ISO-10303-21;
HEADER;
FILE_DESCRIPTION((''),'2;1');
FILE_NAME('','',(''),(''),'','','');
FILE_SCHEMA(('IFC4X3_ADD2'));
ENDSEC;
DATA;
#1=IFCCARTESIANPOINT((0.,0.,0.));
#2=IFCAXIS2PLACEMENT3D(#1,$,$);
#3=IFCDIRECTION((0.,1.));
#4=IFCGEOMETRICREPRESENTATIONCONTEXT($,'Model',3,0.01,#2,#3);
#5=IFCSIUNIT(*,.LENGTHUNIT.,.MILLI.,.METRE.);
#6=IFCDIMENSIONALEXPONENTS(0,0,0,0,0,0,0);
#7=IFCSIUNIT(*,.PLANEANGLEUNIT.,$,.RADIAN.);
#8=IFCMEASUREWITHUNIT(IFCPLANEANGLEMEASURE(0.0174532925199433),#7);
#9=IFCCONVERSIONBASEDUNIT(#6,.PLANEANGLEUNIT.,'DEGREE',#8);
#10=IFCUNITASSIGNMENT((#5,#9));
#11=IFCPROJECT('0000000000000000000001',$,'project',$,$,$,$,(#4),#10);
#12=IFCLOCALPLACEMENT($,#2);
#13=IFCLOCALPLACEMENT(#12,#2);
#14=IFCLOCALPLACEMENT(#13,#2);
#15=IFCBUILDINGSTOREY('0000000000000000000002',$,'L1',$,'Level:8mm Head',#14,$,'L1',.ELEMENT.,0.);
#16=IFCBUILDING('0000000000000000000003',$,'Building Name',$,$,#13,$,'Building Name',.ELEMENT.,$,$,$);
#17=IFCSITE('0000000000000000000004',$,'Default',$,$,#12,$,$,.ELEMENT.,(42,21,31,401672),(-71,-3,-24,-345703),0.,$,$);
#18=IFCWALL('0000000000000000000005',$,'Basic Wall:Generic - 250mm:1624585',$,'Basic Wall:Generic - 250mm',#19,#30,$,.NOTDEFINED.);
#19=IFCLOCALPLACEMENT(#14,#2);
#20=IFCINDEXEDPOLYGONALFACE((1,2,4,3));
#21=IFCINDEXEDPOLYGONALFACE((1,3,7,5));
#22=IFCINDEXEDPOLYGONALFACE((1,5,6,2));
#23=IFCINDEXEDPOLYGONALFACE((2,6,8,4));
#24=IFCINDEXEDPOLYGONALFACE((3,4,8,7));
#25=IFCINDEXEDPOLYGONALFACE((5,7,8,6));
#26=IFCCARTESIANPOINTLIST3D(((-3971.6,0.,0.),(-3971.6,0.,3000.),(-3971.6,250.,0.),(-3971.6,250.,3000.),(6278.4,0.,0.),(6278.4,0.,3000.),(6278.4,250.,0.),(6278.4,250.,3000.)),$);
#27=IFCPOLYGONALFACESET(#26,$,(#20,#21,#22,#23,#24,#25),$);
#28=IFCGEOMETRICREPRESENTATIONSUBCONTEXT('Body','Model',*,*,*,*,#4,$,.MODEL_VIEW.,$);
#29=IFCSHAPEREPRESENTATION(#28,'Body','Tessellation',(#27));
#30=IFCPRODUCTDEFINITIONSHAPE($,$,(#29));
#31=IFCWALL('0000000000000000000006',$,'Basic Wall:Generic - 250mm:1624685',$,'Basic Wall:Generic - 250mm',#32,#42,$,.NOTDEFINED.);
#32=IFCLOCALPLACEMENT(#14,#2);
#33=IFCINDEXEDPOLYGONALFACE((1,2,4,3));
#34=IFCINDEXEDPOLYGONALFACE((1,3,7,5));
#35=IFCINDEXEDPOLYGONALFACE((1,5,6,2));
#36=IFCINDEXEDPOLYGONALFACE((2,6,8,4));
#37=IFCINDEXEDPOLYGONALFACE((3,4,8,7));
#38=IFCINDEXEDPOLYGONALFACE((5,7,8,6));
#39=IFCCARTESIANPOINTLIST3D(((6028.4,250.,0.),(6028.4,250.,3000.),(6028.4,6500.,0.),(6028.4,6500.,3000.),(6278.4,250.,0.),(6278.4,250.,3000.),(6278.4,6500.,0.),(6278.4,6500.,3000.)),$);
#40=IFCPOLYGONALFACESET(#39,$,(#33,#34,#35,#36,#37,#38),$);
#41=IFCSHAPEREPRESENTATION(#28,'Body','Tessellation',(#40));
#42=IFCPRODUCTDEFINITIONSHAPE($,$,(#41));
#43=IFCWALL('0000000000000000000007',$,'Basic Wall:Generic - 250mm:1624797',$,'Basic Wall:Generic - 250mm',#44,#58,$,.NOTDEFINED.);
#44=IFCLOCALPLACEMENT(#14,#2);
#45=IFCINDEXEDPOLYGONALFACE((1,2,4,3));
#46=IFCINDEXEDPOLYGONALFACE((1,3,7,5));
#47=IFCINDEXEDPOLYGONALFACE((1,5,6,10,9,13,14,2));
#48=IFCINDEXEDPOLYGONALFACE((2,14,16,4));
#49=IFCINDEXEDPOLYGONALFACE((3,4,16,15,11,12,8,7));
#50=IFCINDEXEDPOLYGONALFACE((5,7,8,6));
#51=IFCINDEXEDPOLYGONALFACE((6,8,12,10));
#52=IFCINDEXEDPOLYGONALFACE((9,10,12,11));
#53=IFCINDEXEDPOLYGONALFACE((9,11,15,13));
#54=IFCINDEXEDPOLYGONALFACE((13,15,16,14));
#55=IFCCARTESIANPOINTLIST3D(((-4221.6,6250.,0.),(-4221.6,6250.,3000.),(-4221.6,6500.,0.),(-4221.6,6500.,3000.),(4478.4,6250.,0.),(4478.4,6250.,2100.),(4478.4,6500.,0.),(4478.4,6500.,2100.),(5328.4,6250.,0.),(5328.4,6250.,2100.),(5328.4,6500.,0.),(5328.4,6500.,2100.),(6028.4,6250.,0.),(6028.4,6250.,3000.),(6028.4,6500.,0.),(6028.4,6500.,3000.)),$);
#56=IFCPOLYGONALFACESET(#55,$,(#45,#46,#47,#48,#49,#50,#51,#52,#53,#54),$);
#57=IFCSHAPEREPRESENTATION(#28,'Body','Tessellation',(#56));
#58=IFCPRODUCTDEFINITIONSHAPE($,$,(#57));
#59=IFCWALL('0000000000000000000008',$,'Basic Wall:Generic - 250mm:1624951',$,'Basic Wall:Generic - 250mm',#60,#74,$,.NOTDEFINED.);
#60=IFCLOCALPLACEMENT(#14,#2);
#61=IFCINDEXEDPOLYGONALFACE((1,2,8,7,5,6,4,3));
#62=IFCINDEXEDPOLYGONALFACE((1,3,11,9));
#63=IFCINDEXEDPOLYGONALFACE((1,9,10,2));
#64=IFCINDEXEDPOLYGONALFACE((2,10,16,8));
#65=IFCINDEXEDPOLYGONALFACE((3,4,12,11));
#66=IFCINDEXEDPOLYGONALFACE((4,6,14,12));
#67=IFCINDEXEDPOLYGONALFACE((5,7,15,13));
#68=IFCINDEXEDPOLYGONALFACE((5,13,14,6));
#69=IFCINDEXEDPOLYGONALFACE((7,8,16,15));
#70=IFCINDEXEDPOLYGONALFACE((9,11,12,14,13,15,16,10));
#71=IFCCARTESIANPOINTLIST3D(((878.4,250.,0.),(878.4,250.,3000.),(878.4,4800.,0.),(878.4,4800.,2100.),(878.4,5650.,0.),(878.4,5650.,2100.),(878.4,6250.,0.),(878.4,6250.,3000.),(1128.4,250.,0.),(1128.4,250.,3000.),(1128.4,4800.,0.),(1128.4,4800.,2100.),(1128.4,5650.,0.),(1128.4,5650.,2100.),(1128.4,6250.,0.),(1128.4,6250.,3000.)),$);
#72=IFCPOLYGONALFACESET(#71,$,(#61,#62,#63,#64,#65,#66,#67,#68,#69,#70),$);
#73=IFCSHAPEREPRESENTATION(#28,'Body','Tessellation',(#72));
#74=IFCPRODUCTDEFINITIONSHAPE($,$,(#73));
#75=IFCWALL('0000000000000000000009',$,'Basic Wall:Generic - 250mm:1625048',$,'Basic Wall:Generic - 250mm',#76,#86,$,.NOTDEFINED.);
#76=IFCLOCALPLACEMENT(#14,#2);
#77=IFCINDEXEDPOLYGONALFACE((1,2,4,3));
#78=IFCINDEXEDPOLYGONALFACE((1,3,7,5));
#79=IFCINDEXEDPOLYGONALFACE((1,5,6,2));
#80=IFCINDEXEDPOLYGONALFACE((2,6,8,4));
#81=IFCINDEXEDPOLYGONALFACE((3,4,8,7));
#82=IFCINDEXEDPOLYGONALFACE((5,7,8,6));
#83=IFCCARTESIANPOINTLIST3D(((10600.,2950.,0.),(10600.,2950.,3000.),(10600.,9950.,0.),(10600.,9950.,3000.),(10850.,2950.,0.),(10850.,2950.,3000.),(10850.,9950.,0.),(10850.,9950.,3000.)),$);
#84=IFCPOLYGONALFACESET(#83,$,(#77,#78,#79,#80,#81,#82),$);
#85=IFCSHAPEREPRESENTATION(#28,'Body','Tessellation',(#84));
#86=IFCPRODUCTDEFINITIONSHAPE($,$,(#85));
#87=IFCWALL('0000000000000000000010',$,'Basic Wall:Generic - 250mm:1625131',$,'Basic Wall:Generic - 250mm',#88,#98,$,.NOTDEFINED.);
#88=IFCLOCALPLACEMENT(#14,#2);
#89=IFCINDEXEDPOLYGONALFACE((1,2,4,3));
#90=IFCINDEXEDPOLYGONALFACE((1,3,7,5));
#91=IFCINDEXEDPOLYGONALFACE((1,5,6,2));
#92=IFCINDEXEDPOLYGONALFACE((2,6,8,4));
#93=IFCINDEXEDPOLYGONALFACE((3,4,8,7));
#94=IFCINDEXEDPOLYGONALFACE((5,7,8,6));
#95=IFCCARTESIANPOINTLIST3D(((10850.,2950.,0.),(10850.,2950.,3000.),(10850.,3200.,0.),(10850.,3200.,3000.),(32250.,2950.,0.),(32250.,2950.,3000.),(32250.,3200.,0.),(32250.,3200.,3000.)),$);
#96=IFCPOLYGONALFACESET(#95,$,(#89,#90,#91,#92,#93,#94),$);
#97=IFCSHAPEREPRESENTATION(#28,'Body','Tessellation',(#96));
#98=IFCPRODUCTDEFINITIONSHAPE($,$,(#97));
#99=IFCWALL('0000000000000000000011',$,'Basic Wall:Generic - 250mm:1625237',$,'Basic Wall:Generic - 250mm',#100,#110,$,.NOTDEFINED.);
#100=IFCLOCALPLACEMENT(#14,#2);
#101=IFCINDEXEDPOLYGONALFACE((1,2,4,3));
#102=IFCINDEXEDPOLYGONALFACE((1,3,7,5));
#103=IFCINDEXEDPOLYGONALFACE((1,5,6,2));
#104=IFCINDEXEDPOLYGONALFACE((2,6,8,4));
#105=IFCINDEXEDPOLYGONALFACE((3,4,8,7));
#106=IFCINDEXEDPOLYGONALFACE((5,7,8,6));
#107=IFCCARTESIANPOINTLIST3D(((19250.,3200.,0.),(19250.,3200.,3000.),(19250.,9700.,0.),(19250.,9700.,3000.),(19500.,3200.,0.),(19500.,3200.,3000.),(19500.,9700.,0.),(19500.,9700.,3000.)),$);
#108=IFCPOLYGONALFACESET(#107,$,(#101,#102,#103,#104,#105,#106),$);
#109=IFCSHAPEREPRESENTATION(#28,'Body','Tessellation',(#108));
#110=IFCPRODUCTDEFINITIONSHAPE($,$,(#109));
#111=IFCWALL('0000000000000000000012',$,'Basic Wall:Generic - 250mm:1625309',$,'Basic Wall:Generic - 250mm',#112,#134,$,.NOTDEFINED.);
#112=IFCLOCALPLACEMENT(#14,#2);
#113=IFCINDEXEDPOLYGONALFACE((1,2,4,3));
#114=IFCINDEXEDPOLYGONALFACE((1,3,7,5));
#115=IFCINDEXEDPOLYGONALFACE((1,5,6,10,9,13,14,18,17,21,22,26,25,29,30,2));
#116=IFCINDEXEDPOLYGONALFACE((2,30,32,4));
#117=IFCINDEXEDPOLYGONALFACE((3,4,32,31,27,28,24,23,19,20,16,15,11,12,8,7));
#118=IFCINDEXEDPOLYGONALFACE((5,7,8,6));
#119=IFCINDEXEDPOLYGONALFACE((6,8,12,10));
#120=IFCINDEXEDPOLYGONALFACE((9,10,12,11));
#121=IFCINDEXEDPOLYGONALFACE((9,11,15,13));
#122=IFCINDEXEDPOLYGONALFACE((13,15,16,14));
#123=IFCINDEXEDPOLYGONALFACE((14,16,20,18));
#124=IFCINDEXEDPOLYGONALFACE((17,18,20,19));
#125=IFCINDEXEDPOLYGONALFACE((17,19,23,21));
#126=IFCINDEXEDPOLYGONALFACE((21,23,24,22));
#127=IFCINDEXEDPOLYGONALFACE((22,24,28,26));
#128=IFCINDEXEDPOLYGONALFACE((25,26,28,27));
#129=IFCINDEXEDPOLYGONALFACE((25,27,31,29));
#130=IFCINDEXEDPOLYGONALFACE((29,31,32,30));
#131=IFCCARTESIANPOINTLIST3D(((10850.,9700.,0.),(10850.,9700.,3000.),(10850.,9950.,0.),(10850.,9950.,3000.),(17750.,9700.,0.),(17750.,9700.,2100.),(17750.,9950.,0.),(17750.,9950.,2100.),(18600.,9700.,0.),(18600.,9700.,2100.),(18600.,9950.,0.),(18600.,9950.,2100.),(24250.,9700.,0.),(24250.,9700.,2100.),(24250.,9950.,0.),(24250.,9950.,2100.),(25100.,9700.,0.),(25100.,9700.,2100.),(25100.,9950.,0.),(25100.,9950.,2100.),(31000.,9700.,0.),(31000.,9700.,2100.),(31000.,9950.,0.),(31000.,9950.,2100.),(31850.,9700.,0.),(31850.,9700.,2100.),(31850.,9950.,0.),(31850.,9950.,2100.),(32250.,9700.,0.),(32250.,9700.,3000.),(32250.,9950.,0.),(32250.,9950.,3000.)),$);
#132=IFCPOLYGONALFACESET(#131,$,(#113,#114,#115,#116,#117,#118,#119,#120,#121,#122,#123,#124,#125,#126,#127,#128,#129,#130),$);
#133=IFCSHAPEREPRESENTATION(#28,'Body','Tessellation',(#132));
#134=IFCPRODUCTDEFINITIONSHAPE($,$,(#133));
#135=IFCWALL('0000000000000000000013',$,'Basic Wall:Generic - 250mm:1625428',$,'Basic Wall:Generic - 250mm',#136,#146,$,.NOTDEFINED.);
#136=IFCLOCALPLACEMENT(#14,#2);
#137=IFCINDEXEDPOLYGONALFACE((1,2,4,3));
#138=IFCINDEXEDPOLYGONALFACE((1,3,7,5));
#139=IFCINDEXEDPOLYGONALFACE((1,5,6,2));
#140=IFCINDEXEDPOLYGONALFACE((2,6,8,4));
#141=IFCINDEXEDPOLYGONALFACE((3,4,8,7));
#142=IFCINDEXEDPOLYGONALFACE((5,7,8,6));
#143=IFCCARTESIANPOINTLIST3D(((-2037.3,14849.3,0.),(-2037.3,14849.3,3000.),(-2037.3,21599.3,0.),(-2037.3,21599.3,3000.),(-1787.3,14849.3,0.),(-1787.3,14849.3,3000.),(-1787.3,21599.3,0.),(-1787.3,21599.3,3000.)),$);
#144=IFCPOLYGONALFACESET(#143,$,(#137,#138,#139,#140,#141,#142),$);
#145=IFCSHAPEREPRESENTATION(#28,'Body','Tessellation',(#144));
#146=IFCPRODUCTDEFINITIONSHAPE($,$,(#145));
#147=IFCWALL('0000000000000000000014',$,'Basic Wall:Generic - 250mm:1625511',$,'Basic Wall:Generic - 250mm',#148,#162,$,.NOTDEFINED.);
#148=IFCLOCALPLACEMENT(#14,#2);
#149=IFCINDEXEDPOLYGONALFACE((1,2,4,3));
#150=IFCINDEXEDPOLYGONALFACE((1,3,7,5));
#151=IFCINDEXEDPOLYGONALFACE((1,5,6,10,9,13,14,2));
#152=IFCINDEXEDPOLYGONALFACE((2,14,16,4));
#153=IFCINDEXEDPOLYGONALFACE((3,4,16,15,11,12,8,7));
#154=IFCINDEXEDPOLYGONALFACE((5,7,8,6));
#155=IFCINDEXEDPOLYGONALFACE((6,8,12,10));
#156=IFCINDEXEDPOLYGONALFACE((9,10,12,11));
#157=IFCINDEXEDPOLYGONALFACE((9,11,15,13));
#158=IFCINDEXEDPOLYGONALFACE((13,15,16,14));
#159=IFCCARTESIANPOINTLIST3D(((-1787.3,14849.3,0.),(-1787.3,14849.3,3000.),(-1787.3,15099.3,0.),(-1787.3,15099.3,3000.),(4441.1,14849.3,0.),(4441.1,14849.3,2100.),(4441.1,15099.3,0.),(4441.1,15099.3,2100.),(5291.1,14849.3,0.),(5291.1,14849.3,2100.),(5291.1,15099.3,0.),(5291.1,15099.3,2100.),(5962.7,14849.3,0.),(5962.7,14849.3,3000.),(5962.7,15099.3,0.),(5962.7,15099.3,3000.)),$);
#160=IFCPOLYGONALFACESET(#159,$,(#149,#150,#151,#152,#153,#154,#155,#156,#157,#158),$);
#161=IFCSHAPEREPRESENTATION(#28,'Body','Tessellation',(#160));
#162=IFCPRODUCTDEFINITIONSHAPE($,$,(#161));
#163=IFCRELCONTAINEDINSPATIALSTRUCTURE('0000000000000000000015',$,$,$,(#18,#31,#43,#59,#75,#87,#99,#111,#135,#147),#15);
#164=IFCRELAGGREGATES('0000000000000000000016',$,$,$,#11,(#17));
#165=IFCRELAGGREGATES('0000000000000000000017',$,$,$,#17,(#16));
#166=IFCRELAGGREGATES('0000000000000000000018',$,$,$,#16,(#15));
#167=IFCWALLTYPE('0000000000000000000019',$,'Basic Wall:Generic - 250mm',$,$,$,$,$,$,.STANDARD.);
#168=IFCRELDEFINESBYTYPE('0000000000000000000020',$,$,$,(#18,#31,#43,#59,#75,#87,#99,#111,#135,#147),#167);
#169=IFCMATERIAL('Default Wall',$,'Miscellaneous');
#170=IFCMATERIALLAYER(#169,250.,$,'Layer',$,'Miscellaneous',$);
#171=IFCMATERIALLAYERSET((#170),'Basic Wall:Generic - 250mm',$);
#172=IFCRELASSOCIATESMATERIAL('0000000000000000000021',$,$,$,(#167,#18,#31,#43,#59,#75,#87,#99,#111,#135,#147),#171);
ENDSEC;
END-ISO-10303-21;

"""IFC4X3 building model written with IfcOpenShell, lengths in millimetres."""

from ifc_helpers import new_model, entity, si_unit, converted_unit, direction, frame, frame_2d, origin, place, context, subcontext, project, spatial, rectangle, extrude, material, layer, layer_set, type_object, element, save


model = new_model("IFC4X3")

# Units and contexts
model_context = context("Model", 3, precision=0.01, world=origin(), true_north=direction((0.0, 1.0)))
body_context = subcontext(model_context, "Body", "Model", "MODEL_VIEW")
ifc_project = project(units=[si_unit("LENGTHUNIT", "METRE", prefix="MILLI"), converted_unit("PLANEANGLEUNIT", "DEGREE", entity("IfcPlaneAngleMeasure", 0.0174532925199433), si_unit("PLANEANGLEUNIT", "RADIAN"), dimensions=[0, 0, 0, 0, 0, 0, 0])], contexts=[model_context])

# Site, building, storey
site_placement = place(None, origin())
site = spatial("IfcSite", under=ifc_project, at=site_placement, Name="Default", CompositionType="ELEMENT", RefLatitude=(42, 21, 31, 401672), RefLongitude=(-71, -3, -24, -345703), RefElevation=0.0)
building_placement = place(site_placement, origin())
building = spatial("IfcBuilding", under=site, at=building_placement, Name="Building Name", LongName="Building Name", CompositionType="ELEMENT")
storey_placement = place(building_placement, origin())
storey = spatial("IfcBuildingStorey", under=building, at=storey_placement, Name="L1", ObjectType="Level:8mm Head", LongName="L1", CompositionType="ELEMENT", Elevation=0.0)

# Walls
ifc_material = material(Name="Default Wall", Category="Miscellaneous")
ifc_layer = layer(ifc_material, 250.0, Name="Layer", Category="Miscellaneous")
ifc_layer_set = layer_set([ifc_layer], Name="Basic Wall:Generic - 250mm")
wall_type = type_object("IfcWallType", Name="Basic Wall:Generic - 250mm", PredefinedType="STANDARD", material=ifc_layer_set)
wall_1_placement = place(storey_placement, frame((-3971.6, 125.0, 0.0)))
element("IfcWall", 1, at=wall_1_placement, inside=storey, type_object=wall_type, material=ifc_layer_set, Name="Basic Wall:Generic - 250mm:1624585", ObjectType="Basic Wall:Generic - 250mm", PredefinedType="NOTDEFINED", context=body_context, shape_type="SweptSolid", body=[
    extrude(rectangle(XDim=10250.0, YDim=250.0, at=frame_2d((5125.0, 0.0), x_axis=(-1.0, 0.0))), origin(), (0.0, 0.0, 1.0), 3000.0),
])
wall_2_placement = place(storey_placement, frame((6153.4, 250.0, 0.0), z_axis=(0.0, 0.0, 1.0), x_axis=(0.0, 1.0, 0.0)))
element("IfcWall", 2, at=wall_2_placement, inside=storey, type_object=wall_type, material=ifc_layer_set, Name="Basic Wall:Generic - 250mm:1624685", ObjectType="Basic Wall:Generic - 250mm", PredefinedType="NOTDEFINED", context=body_context, shape_type="SweptSolid", body=[
    extrude(rectangle(XDim=6250.0, YDim=250.0, at=frame_2d((3125.0, 0.0), x_axis=(-1.0, 0.0))), origin(), (0.0, 0.0, 1.0), 3000.0),
])

# Walls, openings
wall_3_placement = place(storey_placement, frame((6028.4, 6375.0, 0.0), z_axis=(0.0, 0.0, 1.0), x_axis=(-1.0, 0.0, 0.0)))
wall_3 = element("IfcWall", 3, at=wall_3_placement, inside=storey, type_object=wall_type, material=ifc_layer_set, Name="Basic Wall:Generic - 250mm:1624797", ObjectType="Basic Wall:Generic - 250mm", PredefinedType="NOTDEFINED", context=body_context, shape_type="SweptSolid", body=[
    extrude(rectangle(XDim=10250.0, YDim=250.0, at=frame_2d((5125.0, 0.0), x_axis=(1.0, 0.0))), origin(), (0.0, 0.0, 1.0), 3000.0),
])
opening_1_placement = place(wall_3_placement, frame((700.0, -125.0, 0.0)))
element("IfcOpeningElement", 4, at=opening_1_placement, cuts=wall_3, PredefinedType="OPENING", context=body_context, shape_type="SweptSolid", body=[
    extrude(rectangle(XDim=2100.0, YDim=850.0, at=frame_2d((1050.0, 425.0), x_axis=(1.0, 0.0))), frame((0.0, 0.0, 0.0), z_axis=(0.0, 1.0, 0.0), x_axis=(0.0, 0.0, 1.0)), (0.0, 0.0, 1.0), 250.0),
])
wall_4_placement = place(storey_placement, frame((1003.4, 6250.0, 0.0), z_axis=(0.0, 0.0, 1.0), x_axis=(0.0, -1.0, 0.0)))
wall_4 = element("IfcWall", 5, at=wall_4_placement, inside=storey, type_object=wall_type, material=ifc_layer_set, Name="Basic Wall:Generic - 250mm:1624951", ObjectType="Basic Wall:Generic - 250mm", PredefinedType="NOTDEFINED", context=body_context, shape_type="SweptSolid", body=[
    extrude(rectangle(XDim=6000.0, YDim=250.0, at=frame_2d((3000.0, 0.0), x_axis=(1.0, 0.0))), origin(), (0.0, 0.0, 1.0), 3000.0),
])
opening_2_placement = place(wall_4_placement, frame((1450.0, 125.0, 0.0)))
element("IfcOpeningElement", 6, at=opening_2_placement, cuts=wall_4, PredefinedType="OPENING", context=body_context, shape_type="SweptSolid", body=[
    extrude(rectangle(XDim=2100.0, YDim=850.0, at=frame_2d((1050.0, 425.0), x_axis=(1.0, 0.0))), frame((0.0, 0.0, 0.0), z_axis=(0.0, -1.0, 0.0), x_axis=(0.0, 0.0, 1.0)), (0.0, 0.0, 1.0), 250.0),
])

# Walls
wall_5_placement = place(storey_placement, frame((10725.0, 9950.0, 0.0), z_axis=(0.0, 0.0, 1.0), x_axis=(0.0, -1.0, 0.0)))
element("IfcWall", 7, at=wall_5_placement, inside=storey, type_object=wall_type, material=ifc_layer_set, Name="Basic Wall:Generic - 250mm:1625048", ObjectType="Basic Wall:Generic - 250mm", PredefinedType="NOTDEFINED", context=body_context, shape_type="SweptSolid", body=[
    extrude(rectangle(XDim=7000.0, YDim=250.0, at=frame_2d((3500.0, 0.0), x_axis=(-1.0, 0.0))), origin(), (0.0, 0.0, 1.0), 3000.0),
])
wall_6_placement = place(storey_placement, frame((10850.0, 3075.0, 0.0)))
element("IfcWall", 8, at=wall_6_placement, inside=storey, type_object=wall_type, material=ifc_layer_set, Name="Basic Wall:Generic - 250mm:1625131", ObjectType="Basic Wall:Generic - 250mm", PredefinedType="NOTDEFINED", context=body_context, shape_type="SweptSolid", body=[
    extrude(rectangle(XDim=21400.0, YDim=250.0, at=frame_2d((10700.0, 0.0), x_axis=(-1.0, 0.0))), origin(), (0.0, 0.0, 1.0), 3000.0),
])
wall_7_placement = place(storey_placement, frame((19375.0, 3200.0, 0.0), z_axis=(0.0, 0.0, 1.0), x_axis=(0.0, 1.0, 0.0)))
element("IfcWall", 9, at=wall_7_placement, inside=storey, type_object=wall_type, material=ifc_layer_set, Name="Basic Wall:Generic - 250mm:1625237", ObjectType="Basic Wall:Generic - 250mm", PredefinedType="NOTDEFINED", context=body_context, shape_type="SweptSolid", body=[
    extrude(rectangle(XDim=6500.0, YDim=250.0, at=frame_2d((3250.0, 0.0), x_axis=(-1.0, 0.0))), origin(), (0.0, 0.0, 1.0), 3000.0),
])

# Wall, openings
wall_8_placement = place(storey_placement, frame((32250.0, 9825.0, 0.0), z_axis=(0.0, 0.0, 1.0), x_axis=(-1.0, 0.0, 0.0)))
wall_8 = element("IfcWall", 10, at=wall_8_placement, inside=storey, type_object=wall_type, material=ifc_layer_set, Name="Basic Wall:Generic - 250mm:1625309", ObjectType="Basic Wall:Generic - 250mm", PredefinedType="NOTDEFINED", context=body_context, shape_type="SweptSolid", body=[
    extrude(rectangle(XDim=21400.0, YDim=250.0, at=frame_2d((10700.0, 0.0), x_axis=(1.0, 0.0))), origin(), (0.0, 0.0, 1.0), 3000.0),
])
opening_3_placement = place(wall_8_placement, frame((13650.0, -125.0, 0.0)))
element("IfcOpeningElement", 11, at=opening_3_placement, cuts=wall_8, PredefinedType="OPENING", context=body_context, shape_type="SweptSolid", body=[
    extrude(rectangle(XDim=2100.0, YDim=850.0, at=frame_2d((1050.0, 425.0), x_axis=(1.0, 0.0))), frame((0.0, 0.0, 0.0), z_axis=(0.0, 1.0, 0.0), x_axis=(0.0, 0.0, 1.0)), (0.0, 0.0, 1.0), 250.0),
])
opening_4_placement = place(wall_8_placement, frame((7150.0, -125.0, 0.0)))
element("IfcOpeningElement", 12, at=opening_4_placement, cuts=wall_8, PredefinedType="OPENING", context=body_context, shape_type="SweptSolid", body=[
    extrude(rectangle(XDim=2100.0, YDim=850.0, at=frame_2d((1050.0, 425.0), x_axis=(1.0, 0.0))), frame((0.0, 0.0, 0.0), z_axis=(0.0, 1.0, 0.0), x_axis=(0.0, 0.0, 1.0)), (0.0, 0.0, 1.0), 250.0),
])
opening_5_placement = place(wall_8_placement, frame((400.0, -125.0, 0.0)))
element("IfcOpeningElement", 13, at=opening_5_placement, cuts=wall_8, PredefinedType="OPENING", context=body_context, shape_type="SweptSolid", body=[
    extrude(rectangle(XDim=2100.0, YDim=850.0, at=frame_2d((1050.0, 425.0), x_axis=(1.0, 0.0))), frame((0.0, 0.0, 0.0), z_axis=(0.0, 1.0, 0.0), x_axis=(0.0, 0.0, 1.0)), (0.0, 0.0, 1.0), 250.0),
])

# Wall
wall_9_placement = place(storey_placement, frame((-1912.3, 21599.3, 0.0), z_axis=(0.0, 0.0, 1.0), x_axis=(0.0, -1.0, 0.0)))
element("IfcWall", 14, at=wall_9_placement, inside=storey, type_object=wall_type, material=ifc_layer_set, Name="Basic Wall:Generic - 250mm:1625428", ObjectType="Basic Wall:Generic - 250mm", PredefinedType="NOTDEFINED", context=body_context, shape_type="SweptSolid", body=[
    extrude(rectangle(XDim=6750.0, YDim=250.0, at=frame_2d((3375.0, 0.0), x_axis=(-1.0, 0.0))), origin(), (0.0, 0.0, 1.0), 3000.0),
])

# Wall, opening
wall_10_placement = place(storey_placement, frame((-1787.3, 14974.3, 0.0)))
wall_10 = element("IfcWall", 15, at=wall_10_placement, inside=storey, type_object=wall_type, material=ifc_layer_set, Name="Basic Wall:Generic - 250mm:1625511", ObjectType="Basic Wall:Generic - 250mm", PredefinedType="NOTDEFINED", context=body_context, shape_type="SweptSolid", body=[
    extrude(rectangle(XDim=7750.0, YDim=250.0, at=frame_2d((3875.0, 0.0), x_axis=(1.0, 0.0))), origin(), (0.0, 0.0, 1.0), 3000.0),
])
opening_6_placement = place(wall_10_placement, frame((6228.4, -125.0, 0.0)))
element("IfcOpeningElement", 16, at=opening_6_placement, cuts=wall_10, PredefinedType="OPENING", context=body_context, shape_type="SweptSolid", body=[
    extrude(rectangle(XDim=2100.0, YDim=850.0, at=frame_2d((1050.0, 425.0), x_axis=(1.0, 0.0))), frame((0.0, 0.0, 0.0), z_axis=(0.0, 1.0, 0.0), x_axis=(0.0, 0.0, 1.0)), (0.0, 0.0, 1.0), 250.0),
])

save(model, "model.ifc")
